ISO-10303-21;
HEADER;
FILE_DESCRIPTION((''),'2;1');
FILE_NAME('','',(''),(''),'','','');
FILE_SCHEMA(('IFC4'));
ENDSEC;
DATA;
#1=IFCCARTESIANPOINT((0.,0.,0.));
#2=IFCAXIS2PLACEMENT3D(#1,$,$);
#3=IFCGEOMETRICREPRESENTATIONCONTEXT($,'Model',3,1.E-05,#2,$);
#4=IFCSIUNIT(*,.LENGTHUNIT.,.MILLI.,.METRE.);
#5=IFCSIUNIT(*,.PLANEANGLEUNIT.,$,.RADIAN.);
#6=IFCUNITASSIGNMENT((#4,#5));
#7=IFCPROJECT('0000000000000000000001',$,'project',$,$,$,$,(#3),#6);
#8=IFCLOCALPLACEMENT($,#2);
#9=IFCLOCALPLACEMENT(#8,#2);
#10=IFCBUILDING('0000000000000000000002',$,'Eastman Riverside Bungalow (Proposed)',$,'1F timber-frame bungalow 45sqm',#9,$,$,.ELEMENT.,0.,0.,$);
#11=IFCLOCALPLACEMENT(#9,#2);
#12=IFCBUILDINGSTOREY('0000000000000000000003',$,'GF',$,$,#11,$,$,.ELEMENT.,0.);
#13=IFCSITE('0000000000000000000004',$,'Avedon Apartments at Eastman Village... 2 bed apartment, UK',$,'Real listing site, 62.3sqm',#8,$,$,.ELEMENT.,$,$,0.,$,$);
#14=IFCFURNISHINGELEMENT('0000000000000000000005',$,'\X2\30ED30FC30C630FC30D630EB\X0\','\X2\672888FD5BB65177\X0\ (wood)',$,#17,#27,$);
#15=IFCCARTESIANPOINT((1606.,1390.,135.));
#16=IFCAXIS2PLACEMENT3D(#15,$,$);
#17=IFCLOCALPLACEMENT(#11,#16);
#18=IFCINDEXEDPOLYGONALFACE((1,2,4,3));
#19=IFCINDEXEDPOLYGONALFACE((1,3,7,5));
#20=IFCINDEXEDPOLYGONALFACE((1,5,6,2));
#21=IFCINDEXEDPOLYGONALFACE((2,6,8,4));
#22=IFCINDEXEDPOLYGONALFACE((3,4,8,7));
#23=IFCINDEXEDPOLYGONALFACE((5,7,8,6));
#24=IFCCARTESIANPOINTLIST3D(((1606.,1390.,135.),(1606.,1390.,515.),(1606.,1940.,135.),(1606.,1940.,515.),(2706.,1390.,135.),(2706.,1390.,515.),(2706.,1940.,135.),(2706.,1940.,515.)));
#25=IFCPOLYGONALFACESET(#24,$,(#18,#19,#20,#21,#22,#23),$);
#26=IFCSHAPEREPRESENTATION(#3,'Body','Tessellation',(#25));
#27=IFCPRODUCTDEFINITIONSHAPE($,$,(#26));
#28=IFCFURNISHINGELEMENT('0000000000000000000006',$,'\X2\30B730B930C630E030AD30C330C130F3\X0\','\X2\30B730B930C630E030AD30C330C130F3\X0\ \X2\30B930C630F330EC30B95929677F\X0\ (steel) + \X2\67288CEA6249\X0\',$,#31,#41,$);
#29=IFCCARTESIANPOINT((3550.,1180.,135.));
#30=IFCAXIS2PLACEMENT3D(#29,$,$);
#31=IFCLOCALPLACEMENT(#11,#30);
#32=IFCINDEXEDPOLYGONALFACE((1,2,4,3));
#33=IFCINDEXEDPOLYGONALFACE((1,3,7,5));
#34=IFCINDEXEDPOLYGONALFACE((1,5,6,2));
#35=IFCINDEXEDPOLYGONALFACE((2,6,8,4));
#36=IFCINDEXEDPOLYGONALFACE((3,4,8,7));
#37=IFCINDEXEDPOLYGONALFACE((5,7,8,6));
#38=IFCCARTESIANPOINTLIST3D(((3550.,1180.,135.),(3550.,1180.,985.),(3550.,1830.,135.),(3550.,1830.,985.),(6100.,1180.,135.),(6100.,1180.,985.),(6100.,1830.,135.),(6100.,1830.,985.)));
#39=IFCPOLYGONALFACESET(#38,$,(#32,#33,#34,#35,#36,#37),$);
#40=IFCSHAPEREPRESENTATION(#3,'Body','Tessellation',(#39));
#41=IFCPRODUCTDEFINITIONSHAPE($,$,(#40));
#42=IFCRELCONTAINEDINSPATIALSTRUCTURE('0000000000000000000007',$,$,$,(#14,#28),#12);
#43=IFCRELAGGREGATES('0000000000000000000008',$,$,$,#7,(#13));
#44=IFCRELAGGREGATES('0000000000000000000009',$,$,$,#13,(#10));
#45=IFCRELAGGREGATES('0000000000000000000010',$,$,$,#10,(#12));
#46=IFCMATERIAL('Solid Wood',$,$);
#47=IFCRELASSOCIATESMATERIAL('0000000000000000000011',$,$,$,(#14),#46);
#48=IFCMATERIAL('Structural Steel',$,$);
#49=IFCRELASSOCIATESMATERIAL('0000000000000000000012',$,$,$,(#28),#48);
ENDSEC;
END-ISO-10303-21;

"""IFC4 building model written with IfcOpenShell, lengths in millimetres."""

from ifc_helpers import new_model, si_unit, frame, frame_2d, origin, place, context, project, spatial, rectangle, extrude, material, element, save


model = new_model("IFC4")

# Units and contexts
model_context = context("Model", 3, precision=1e-05, world=origin())
ifc_project = project(units=[si_unit("LENGTHUNIT", "METRE", prefix="MILLI"), si_unit("PLANEANGLEUNIT", "RADIAN")], contexts=[model_context])

# Site, building, storey
site_placement = place(None, origin())
site = spatial("IfcSite", under=ifc_project, at=site_placement, Name="Avedon Apartments at Eastman Village... 2 bed apartment, UK", ObjectType="Real listing site, 62.3sqm", CompositionType="ELEMENT", RefElevation=0.0)
building_placement = place(site_placement, origin())
building = spatial("IfcBuilding", under=site, at=building_placement, Name="Eastman Riverside Bungalow (Proposed)", ObjectType="1F timber-frame bungalow 45sqm", CompositionType="ELEMENT", ElevationOfRefHeight=0.0, ElevationOfTerrain=0.0)
storey_placement = place(building_placement, origin())
storey = spatial("IfcBuildingStorey", under=building, at=storey_placement, Name="GF", CompositionType="ELEMENT", Elevation=0.0)

# Shared definitions
ifc_material_1 = material(Name="Solid Wood")

# Furnishing elements
furnishing_1_placement = place(storey_placement, frame((1606.0, 1390.0, 135.0)))
element("IfcFurnishingElement", 1, at=furnishing_1_placement, inside=storey, material=ifc_material_1, Name="ローテーブル", Description="木製家具 (wood)", context=model_context, shape_type="SweptSolid", body=[
    extrude(rectangle(XDim=1100.0, YDim=550.0, at=frame_2d((550.0, 275.0))), frame((1606.0, 1390.0, 135.0)), (0.0, 0.0, 1.0), 380.0),
])
ifc_material_2 = material(Name="Structural Steel")
furnishing_2_placement = place(storey_placement, frame((3550.0, 1180.0, 135.0)))
element("IfcFurnishingElement", 2, at=furnishing_2_placement, inside=storey, material=ifc_material_2, Name="システムキッチン", Description="システムキッチン ステンレス天板 (steel) + 木質扉", context=model_context, shape_type="SweptSolid", body=[
    extrude(rectangle(XDim=2550.0, YDim=650.0, at=frame_2d((1275.0, 325.0))), frame((3550.0, 1180.0, 135.0)), (0.0, 0.0, 1.0), 850.0),
])

save(model, "model.ifc")
